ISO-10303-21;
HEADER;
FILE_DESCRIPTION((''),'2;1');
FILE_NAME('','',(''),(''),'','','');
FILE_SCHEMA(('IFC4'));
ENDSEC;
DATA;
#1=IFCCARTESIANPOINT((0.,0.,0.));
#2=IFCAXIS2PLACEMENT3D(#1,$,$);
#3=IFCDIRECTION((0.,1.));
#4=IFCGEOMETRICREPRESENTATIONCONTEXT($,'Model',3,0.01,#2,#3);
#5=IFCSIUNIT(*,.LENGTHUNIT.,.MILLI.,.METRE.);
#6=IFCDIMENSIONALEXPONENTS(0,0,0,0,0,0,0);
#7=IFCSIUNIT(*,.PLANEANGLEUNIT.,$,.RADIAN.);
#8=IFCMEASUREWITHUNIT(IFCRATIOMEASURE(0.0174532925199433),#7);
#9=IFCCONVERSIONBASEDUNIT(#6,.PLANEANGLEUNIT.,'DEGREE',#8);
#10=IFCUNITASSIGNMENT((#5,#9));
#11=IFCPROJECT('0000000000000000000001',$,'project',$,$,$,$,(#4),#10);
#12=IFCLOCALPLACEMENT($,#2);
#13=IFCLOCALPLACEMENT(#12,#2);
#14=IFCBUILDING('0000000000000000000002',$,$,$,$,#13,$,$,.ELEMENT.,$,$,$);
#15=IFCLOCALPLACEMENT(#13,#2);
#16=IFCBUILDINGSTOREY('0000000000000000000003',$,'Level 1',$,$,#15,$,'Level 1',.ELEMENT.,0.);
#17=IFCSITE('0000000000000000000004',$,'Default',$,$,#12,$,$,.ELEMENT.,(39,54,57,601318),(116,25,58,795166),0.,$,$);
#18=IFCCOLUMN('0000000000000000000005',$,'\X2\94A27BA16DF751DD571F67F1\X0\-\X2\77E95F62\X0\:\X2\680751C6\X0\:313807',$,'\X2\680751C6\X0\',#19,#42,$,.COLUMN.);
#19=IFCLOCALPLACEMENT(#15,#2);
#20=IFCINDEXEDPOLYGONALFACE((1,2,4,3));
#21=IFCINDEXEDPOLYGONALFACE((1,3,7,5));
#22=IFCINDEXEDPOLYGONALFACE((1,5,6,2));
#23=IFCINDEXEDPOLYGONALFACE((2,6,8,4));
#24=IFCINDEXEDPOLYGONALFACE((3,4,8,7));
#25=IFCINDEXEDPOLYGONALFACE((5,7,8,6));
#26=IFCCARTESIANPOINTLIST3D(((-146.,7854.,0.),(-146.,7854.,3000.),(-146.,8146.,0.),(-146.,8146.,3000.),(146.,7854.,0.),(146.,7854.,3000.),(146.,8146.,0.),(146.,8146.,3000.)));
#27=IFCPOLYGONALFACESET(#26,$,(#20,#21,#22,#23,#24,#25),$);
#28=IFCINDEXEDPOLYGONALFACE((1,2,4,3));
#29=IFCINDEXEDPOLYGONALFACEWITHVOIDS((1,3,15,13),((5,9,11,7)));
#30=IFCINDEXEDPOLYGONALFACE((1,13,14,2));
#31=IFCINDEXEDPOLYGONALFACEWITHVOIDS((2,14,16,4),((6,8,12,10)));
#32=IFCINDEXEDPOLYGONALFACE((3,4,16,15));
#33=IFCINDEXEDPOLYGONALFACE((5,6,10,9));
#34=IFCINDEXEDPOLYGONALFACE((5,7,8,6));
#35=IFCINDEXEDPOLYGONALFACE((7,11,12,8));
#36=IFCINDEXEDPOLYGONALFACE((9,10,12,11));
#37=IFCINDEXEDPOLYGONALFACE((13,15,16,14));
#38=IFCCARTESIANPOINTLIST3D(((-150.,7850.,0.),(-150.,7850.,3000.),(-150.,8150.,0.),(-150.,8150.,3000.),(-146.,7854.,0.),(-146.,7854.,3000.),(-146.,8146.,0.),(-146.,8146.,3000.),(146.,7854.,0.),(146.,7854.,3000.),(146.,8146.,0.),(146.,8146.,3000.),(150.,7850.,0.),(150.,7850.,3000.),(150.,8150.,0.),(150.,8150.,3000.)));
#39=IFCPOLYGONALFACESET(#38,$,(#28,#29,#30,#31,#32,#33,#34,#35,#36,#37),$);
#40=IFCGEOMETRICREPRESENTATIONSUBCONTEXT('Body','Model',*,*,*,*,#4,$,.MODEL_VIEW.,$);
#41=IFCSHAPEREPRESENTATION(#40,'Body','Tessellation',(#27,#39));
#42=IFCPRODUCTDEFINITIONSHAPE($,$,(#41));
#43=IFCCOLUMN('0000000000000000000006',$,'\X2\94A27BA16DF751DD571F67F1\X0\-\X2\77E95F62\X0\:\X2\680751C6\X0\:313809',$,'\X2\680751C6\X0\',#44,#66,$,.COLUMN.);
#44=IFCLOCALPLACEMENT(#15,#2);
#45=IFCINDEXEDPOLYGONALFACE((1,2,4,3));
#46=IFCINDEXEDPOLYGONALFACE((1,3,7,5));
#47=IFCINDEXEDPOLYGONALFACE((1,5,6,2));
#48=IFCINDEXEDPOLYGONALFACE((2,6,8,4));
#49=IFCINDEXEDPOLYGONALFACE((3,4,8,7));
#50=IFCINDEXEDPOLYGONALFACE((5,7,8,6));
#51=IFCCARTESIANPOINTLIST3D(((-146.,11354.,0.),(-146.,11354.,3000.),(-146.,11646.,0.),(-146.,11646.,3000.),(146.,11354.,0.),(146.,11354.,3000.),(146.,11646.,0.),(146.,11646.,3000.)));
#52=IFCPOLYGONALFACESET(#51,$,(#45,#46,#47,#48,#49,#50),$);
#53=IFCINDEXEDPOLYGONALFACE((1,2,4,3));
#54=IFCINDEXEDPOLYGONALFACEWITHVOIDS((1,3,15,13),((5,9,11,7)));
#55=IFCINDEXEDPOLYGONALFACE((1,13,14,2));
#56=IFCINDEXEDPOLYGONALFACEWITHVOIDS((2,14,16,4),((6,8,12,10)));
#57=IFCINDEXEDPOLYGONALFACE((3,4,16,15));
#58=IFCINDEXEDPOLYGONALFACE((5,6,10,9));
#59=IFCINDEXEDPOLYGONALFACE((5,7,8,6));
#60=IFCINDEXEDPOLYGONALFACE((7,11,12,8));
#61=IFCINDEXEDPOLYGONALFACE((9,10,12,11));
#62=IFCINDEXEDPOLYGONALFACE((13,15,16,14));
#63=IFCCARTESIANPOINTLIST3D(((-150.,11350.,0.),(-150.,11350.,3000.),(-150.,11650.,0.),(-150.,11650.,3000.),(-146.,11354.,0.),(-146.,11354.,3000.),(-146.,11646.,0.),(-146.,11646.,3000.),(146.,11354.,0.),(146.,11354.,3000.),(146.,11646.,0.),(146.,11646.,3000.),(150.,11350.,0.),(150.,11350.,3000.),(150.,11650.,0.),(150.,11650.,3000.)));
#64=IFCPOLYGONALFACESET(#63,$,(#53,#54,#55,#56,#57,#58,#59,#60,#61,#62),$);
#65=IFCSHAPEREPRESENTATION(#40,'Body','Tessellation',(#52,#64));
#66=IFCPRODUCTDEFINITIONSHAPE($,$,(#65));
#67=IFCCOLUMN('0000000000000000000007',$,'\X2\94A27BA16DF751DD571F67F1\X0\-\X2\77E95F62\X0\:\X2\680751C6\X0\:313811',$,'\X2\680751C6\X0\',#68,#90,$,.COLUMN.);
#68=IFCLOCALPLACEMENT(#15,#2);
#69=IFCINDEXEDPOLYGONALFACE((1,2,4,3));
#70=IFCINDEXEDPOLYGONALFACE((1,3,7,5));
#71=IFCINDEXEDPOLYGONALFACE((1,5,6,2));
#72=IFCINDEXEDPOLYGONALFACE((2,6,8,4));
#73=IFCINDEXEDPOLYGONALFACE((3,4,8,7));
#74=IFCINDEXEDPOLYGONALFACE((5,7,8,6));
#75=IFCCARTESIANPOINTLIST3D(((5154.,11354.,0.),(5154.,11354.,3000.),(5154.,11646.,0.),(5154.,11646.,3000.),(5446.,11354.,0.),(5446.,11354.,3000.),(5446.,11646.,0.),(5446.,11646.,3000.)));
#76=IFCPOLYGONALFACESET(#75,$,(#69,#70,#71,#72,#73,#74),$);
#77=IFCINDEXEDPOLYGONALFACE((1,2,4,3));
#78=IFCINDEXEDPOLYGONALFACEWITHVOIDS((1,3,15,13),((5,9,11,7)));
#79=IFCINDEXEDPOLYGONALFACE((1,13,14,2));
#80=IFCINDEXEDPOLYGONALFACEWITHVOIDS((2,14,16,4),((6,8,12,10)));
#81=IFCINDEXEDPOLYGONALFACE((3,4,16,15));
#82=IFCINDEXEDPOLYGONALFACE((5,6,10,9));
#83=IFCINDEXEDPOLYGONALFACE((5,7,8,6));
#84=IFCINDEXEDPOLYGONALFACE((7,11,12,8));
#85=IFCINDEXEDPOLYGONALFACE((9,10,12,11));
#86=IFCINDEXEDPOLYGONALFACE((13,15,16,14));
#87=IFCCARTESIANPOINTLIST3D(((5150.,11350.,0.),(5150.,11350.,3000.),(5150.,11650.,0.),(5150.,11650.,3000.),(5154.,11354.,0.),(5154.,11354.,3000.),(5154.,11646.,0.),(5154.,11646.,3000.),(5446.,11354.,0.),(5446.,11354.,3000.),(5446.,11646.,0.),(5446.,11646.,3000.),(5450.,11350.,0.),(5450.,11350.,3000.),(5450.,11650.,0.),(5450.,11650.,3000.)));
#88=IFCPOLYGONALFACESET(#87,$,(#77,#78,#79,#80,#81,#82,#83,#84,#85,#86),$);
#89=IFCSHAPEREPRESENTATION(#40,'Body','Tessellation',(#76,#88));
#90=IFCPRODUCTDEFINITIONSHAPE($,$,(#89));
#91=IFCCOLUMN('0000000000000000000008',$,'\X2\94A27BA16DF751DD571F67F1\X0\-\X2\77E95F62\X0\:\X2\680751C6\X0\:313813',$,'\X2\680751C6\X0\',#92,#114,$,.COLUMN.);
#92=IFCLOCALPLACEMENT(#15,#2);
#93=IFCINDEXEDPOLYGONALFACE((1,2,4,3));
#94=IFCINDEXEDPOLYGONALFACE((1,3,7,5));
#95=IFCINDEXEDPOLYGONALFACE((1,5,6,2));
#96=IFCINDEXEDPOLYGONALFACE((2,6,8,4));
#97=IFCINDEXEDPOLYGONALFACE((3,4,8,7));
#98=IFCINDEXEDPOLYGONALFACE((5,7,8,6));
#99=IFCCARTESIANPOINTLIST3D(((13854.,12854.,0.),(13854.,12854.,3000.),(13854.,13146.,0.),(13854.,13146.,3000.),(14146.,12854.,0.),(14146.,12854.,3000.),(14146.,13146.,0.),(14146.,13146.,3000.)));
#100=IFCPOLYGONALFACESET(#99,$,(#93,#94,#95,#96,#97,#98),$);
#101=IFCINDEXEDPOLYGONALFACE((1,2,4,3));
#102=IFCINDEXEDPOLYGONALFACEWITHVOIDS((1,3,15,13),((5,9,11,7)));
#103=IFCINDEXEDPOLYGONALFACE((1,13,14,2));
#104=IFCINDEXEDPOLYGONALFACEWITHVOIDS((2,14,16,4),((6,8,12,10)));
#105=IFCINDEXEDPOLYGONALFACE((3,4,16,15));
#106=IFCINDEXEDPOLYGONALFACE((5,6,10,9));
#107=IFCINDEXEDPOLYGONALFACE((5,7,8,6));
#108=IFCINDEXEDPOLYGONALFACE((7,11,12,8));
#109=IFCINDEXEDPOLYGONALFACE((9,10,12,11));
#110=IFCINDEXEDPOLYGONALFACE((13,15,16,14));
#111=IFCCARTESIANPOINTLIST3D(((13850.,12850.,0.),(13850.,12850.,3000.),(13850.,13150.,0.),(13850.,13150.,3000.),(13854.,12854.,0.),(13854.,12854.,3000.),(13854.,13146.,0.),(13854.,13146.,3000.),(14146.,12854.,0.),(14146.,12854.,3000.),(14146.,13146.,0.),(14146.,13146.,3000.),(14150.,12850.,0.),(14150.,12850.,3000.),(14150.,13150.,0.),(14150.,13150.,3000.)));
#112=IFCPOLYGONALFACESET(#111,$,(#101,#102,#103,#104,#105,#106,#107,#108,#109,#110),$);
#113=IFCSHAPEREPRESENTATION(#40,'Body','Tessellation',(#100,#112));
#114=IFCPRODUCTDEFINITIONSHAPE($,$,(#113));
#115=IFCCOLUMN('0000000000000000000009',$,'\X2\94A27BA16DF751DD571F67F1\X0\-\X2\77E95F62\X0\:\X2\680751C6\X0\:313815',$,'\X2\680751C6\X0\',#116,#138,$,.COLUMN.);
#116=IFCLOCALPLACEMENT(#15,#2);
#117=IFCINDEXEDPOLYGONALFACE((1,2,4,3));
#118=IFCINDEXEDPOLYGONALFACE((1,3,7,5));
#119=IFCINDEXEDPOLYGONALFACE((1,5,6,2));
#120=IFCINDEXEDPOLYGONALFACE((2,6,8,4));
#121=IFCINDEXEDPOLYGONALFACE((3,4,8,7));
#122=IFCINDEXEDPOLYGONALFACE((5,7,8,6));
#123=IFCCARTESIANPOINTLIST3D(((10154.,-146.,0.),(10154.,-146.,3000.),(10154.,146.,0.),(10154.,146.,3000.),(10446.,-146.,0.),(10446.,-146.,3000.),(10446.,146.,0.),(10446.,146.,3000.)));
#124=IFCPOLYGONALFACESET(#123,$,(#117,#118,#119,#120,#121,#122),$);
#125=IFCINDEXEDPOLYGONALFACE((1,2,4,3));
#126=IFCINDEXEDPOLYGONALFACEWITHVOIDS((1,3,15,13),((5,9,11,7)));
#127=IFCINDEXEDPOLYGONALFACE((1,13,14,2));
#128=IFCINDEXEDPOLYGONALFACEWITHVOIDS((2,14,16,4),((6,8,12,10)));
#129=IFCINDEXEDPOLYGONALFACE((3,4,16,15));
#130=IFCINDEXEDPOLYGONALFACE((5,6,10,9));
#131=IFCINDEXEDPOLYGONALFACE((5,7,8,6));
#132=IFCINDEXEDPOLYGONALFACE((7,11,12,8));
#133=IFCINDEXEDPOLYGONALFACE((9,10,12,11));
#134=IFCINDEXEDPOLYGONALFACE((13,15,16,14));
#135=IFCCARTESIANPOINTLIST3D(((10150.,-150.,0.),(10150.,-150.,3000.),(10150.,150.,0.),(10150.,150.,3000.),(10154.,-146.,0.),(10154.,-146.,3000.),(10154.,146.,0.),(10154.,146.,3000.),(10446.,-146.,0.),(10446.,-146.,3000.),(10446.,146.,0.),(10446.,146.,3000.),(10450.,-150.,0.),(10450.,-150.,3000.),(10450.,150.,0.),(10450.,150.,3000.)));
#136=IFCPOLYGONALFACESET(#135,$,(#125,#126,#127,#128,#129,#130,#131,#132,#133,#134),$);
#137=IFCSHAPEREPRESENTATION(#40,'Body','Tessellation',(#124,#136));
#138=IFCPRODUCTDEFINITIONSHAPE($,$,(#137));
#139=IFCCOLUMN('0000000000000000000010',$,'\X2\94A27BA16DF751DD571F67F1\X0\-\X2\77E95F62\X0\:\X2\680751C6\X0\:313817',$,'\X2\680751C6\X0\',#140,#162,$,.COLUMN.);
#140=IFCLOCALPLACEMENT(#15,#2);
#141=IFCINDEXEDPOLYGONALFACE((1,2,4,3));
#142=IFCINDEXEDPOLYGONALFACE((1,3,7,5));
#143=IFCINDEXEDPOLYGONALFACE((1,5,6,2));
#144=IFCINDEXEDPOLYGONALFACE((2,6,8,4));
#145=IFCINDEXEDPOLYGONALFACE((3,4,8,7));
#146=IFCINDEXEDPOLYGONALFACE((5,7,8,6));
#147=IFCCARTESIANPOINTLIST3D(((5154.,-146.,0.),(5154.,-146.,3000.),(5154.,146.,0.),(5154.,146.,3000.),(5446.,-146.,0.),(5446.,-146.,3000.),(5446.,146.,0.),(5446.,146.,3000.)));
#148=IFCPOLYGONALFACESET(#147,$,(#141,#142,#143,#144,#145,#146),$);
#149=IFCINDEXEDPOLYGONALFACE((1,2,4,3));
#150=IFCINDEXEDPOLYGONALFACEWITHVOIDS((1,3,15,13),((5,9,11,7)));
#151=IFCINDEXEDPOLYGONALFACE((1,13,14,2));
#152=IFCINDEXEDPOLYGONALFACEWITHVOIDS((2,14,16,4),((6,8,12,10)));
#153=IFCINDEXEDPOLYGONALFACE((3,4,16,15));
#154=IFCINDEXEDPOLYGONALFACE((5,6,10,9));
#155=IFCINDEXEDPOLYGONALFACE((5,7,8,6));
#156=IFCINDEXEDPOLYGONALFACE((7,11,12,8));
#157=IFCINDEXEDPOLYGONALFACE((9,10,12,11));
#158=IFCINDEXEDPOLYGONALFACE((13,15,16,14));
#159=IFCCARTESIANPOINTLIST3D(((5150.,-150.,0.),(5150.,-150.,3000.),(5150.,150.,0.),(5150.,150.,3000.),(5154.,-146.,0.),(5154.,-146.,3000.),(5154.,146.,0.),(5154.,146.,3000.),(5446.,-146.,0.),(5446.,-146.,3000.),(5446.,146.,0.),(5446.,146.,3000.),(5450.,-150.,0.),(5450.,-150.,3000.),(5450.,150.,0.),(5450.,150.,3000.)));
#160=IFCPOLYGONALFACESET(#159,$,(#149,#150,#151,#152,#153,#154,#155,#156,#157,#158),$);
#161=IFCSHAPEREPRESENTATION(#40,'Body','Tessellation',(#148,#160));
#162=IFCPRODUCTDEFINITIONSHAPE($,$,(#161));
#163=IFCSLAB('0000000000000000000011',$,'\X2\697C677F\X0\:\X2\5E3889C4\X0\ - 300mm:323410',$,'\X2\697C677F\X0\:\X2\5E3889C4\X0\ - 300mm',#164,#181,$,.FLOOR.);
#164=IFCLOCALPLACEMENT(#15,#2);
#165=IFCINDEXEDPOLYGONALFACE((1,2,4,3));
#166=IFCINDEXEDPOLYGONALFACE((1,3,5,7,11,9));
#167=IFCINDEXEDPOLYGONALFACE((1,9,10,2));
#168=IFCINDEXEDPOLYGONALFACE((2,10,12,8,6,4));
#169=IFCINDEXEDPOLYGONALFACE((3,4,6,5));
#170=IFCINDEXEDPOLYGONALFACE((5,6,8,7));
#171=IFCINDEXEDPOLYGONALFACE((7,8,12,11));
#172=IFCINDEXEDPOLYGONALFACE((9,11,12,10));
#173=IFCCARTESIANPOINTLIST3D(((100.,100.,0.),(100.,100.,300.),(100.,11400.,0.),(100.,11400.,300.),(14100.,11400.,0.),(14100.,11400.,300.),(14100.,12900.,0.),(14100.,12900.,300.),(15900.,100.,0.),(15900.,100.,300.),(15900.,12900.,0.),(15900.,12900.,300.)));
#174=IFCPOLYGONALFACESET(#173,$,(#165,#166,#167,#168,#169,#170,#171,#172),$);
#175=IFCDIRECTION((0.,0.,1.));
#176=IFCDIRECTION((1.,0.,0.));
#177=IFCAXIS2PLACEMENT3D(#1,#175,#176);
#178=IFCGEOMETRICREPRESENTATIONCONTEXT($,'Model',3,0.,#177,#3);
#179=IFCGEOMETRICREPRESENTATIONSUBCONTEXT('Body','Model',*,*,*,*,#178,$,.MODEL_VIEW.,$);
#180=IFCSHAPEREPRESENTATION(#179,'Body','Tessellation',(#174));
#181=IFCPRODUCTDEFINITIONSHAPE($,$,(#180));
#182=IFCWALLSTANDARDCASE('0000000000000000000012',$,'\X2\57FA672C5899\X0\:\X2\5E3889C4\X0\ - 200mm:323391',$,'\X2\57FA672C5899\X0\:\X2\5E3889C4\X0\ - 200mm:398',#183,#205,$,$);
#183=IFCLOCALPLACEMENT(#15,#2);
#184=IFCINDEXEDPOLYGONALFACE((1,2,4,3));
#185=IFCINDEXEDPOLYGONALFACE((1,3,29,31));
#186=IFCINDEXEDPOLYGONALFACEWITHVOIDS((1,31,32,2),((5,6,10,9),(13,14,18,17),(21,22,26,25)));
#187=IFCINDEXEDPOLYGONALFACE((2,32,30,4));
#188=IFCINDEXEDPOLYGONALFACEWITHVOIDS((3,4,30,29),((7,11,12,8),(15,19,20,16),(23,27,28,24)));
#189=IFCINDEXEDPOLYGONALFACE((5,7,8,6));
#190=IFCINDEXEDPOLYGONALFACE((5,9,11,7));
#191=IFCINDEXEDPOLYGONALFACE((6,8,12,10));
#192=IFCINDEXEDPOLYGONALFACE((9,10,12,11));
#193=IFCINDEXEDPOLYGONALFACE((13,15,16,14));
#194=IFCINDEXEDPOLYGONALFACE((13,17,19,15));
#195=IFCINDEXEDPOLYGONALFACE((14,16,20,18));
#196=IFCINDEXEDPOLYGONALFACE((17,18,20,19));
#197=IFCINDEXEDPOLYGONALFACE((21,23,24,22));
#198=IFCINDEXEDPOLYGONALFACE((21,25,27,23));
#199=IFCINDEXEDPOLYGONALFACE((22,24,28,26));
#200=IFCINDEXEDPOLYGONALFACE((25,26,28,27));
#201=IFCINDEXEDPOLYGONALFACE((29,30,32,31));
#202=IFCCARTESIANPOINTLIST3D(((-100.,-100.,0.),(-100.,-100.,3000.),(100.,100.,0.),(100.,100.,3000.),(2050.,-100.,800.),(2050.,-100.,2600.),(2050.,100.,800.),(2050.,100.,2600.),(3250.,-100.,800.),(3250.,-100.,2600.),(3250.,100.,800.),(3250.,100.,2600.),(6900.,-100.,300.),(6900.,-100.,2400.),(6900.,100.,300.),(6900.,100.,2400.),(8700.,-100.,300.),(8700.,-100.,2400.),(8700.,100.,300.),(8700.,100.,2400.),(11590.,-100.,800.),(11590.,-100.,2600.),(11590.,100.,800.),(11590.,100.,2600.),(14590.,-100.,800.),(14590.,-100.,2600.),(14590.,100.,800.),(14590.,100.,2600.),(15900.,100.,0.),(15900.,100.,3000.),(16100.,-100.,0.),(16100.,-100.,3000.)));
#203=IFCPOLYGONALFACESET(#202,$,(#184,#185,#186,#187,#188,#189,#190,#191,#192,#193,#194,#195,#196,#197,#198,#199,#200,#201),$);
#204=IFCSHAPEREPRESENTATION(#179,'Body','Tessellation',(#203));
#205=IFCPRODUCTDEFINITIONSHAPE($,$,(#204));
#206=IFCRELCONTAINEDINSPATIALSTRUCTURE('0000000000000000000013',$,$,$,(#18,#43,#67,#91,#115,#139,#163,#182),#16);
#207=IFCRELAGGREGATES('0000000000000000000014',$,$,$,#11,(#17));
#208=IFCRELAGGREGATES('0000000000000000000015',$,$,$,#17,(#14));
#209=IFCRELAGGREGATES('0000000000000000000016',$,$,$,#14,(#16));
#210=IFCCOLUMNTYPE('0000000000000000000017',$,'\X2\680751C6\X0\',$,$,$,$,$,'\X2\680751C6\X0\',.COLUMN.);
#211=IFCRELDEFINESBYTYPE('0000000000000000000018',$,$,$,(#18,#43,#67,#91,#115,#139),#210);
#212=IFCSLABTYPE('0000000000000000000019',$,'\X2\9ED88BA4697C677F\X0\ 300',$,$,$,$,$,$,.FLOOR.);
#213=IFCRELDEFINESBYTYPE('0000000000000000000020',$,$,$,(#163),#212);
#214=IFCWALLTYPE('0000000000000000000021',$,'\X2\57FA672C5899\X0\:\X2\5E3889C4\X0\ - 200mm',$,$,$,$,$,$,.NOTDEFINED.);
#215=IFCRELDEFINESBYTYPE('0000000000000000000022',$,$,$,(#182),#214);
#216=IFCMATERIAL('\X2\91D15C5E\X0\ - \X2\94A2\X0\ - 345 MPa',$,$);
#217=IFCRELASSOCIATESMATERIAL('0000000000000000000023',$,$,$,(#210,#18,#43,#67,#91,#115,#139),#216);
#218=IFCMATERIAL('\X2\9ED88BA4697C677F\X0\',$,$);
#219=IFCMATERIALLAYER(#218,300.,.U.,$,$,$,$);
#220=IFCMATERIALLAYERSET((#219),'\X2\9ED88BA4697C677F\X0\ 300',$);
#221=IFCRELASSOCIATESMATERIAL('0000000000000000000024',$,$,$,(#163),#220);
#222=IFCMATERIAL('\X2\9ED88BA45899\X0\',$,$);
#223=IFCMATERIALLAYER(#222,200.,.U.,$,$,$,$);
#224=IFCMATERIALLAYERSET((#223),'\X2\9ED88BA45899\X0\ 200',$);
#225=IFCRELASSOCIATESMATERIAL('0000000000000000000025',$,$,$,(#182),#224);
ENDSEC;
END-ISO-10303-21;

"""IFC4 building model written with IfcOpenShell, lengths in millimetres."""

from ifc_helpers import new_model, entity, si_unit, converted_unit, direction, frame, origin, origin_with_axes, origin_2d_with_axis, place, context, subcontext, project, spatial, polyline, rectangle, outline, extrude, source, transform, mapped, material, layer, layer_set, layer_usage, type_object, type_shapes, element, save


model = new_model("IFC4")

# Units and contexts
model_context_1 = context("Model", 3, precision=0.01, world=origin(), true_north=direction((0.0, 1.0)))
model_context_2 = context("Model", 3, precision=0.0, world=origin_with_axes(), true_north=direction((0.0, 1.0)))
body_context_1 = subcontext(model_context_1, "Body", "Model", "MODEL_VIEW")
body_context_2 = subcontext(model_context_2, "Body", "Model", "MODEL_VIEW")
ifc_project = project(units=[si_unit("LENGTHUNIT", "METRE", prefix="MILLI"), converted_unit("PLANEANGLEUNIT", "DEGREE", entity("IfcRatioMeasure", 0.0174532925199433), si_unit("PLANEANGLEUNIT", "RADIAN"), dimensions=[0, 0, 0, 0, 0, 0, 0])], contexts=[model_context_1])

# Site, building, storey
site_placement = place(None, origin())
site = spatial("IfcSite", under=ifc_project, at=site_placement, Name="Default", CompositionType="ELEMENT", RefLatitude=(39, 54, 57, 601318), RefLongitude=(116, 25, 58, 795166), RefElevation=0.0)
building_placement = place(site_placement, origin())
building = spatial("IfcBuilding", under=site, at=building_placement, CompositionType="ELEMENT")
storey_placement = place(building_placement, origin())
storey = spatial("IfcBuildingStorey", under=building, at=storey_placement, Name="Level 1", LongName="Level 1", CompositionType="ELEMENT", Elevation=0.0)

# Columns
ifc_material_1 = material(Name="金属 - 钢 - 345 MPa")
column_type = type_object("IfcColumnType", Name="标准", ElementType="标准", PredefinedType="COLUMN", material=ifc_material_1)
shared_shape = source(origin(), body_context_1, "Body", "SweptSolid", [
    extrude(rectangle(XDim=292.0, YDim=292.0, at=origin_2d_with_axis()), frame((0.0, 0.0, 0.0), z_axis=(0.0, 0.0, 1.0), x_axis=(-1.0, 0.0, 0.0)), (0.0, 0.0, 1.0), 3000.0),
    extrude(outline(polyline([(-150.0, -150.0), (150.0, -150.0), (150.0, 150.0), (-150.0, 150.0), (-150.0, -150.0)]), holes=[polyline([(-146.0, -146.0), (-146.0, 146.0), (146.0, 146.0), (146.0, -146.0), (-146.0, -146.0)])]), frame((0.0, 0.0, 0.0), z_axis=(0.0, 0.0, 1.0), x_axis=(-1.0, 0.0, 0.0)), (0.0, 0.0, 1.0), 3000.0),
])
type_shapes(column_type, [shared_shape])
for number, where, name in (
    (1, (0.0, 8000.0, 0.0), "钢管混凝土柱-矩形:标准:313807"),
    (2, (0.0, 11500.0, 0.0), "钢管混凝土柱-矩形:标准:313809"),
    (3, (5300.0, 11500.0, 0.0), "钢管混凝土柱-矩形:标准:313811"),
    (4, (14000.0, 13000.0, 0.0), "钢管混凝土柱-矩形:标准:313813"),
    (5, (10300.0, 0.0, 0.0), "钢管混凝土柱-矩形:标准:313815"),
    (6, (5300.0, 0.0, 0.0), "钢管混凝土柱-矩形:标准:313817"),
):
    element("IfcColumn", number, at=place(storey_placement, frame(where)), inside=storey, type_object=column_type, material=ifc_material_1, Name=name, ObjectType="标准", PredefinedType="COLUMN", context=body_context_1, shape_type="MappedRepresentation", body=[
        mapped(shared_shape, transform((0.0, 0.0, 0.0), scale=1.0)),
    ])

# Slab
ifc_material_2 = material(Name="默认楼板")
ifc_layer_1 = layer(ifc_material_2, 300.0, ventilated="UNKNOWN")
ifc_layer_set_1 = layer_set([ifc_layer_1], Name="默认楼板 300")
ifc_layer_usage_1 = layer_usage(ifc_layer_set_1, "AXIS3", "NEGATIVE", 300.0)
slab_type = type_object("IfcSlabType", Name="默认楼板 300", PredefinedType="FLOOR")
placement_1 = place(None, origin_with_axes())
placement_2 = place(placement_1, origin_with_axes())
placement_3 = place(placement_2, origin_with_axes())
slab_placement = place(placement_3, frame((100.0, 100.0, 0.0), z_axis=(0.0, 0.0, 1.0), x_axis=(1.0, 0.0, 0.0)))
element("IfcSlab", 7, at=slab_placement, inside=storey, type_object=slab_type, material=ifc_layer_usage_1, Name="楼板:常规 - 300mm:323410", ObjectType="楼板:常规 - 300mm", PredefinedType="FLOOR", context=body_context_2, shape_type="SweptSolid", body=[
    extrude(outline(polyline([(0.0, 0.0), (15800.0, 0.0), (15800.0, 12800.0), (14000.0, 12800.0), (14000.0, 11300.0), (0.0, 11300.0), (0.0, 0.0)])), origin_with_axes(), (0.0, 0.0, 1.0), 300.0),
])

# Wall, openings
ifc_material_3 = material(Name="默认墙")
ifc_layer_2 = layer(ifc_material_3, 200.0, ventilated="UNKNOWN")
ifc_layer_set_2 = layer_set([ifc_layer_2], Name="默认墙 200")
ifc_layer_usage_2 = layer_usage(ifc_layer_set_2, "AXIS2", "POSITIVE", -100.0)
wall_type = type_object("IfcWallType", Name="基本墙:常规 - 200mm", PredefinedType="NOTDEFINED")
wall_1_placement = place(placement_3, frame((16000.0, 0.0, 0.0), z_axis=(0.0, 0.0, 1.0), x_axis=(-1.0, 0.0, 0.0)))
wall_1 = element("IfcWallStandardCase", 8, at=wall_1_placement, inside=storey, type_object=wall_type, material=ifc_layer_usage_2, Name="基本墙:常规 - 200mm:323391", ObjectType="基本墙:常规 - 200mm:398", context=body_context_2, shape_type="SweptSolid", body=[
    extrude(outline(polyline([(100.0, -100.0), (15900.0, -100.0), (16100.0, 100.0), (-100.0, 100.0), (100.0, -100.0)])), origin_with_axes(), (0.0, 0.0, 1.0), 3000.0),
])
opening_1_placement = place(wall_1_placement, frame((13350.0, 0.0, 800.0), z_axis=(0.0, 0.0, 1.0), x_axis=(1.0, 0.0, 0.0)))
element("IfcOpeningElement", 9, at=opening_1_placement, cuts=wall_1, context=body_context_2, shape_type="SweptSolid", body=[
    extrude(outline(polyline([(-600.0, 0.0), (-600.0, -1800.0), (600.0, -1800.0), (600.0, 0.0), (-600.0, 0.0)])), frame((0.0, -100.0, 0.0), z_axis=(0.0, 1.0, 0.0), x_axis=(1.0, 0.0, 0.0)), (0.0, 0.0, 1.0), 200.0),
])
opening_2_placement = place(wall_1_placement, frame((2910.0, 0.0, 800.0), z_axis=(0.0, 0.0, 1.0), x_axis=(1.0, 0.0, 0.0)))
element("IfcOpeningElement", 10, at=opening_2_placement, cuts=wall_1, context=body_context_2, shape_type="SweptSolid", body=[
    extrude(outline(polyline([(-1500.0, 0.0), (-1500.0, -1800.0), (1500.0, -1800.0), (1500.0, 0.0), (-1500.0, 0.0)])), frame((0.0, -100.0, 0.0), z_axis=(0.0, 1.0, 0.0), x_axis=(1.0, 0.0, 0.0)), (0.0, 0.0, 1.0), 200.0),
])
opening_3_placement = place(wall_1_placement, frame((8200.0, 0.0, 300.0), z_axis=(0.0, 0.0, 1.0), x_axis=(1.0, 0.0, 0.0)))
element("IfcOpeningElement", 11, at=opening_3_placement, cuts=wall_1, context=body_context_2, shape_type="SweptSolid", body=[
    extrude(outline(polyline([(-900.0, 0.0), (-900.0, -2100.0), (900.0, -2100.0), (900.0, 0.0), (-900.0, 0.0)])), frame((0.0, -100.0, 0.0), z_axis=(0.0, 1.0, 0.0), x_axis=(1.0, 0.0, 0.0)), (0.0, 0.0, 1.0), 200.0),
])

save(model, "model.ifc")
